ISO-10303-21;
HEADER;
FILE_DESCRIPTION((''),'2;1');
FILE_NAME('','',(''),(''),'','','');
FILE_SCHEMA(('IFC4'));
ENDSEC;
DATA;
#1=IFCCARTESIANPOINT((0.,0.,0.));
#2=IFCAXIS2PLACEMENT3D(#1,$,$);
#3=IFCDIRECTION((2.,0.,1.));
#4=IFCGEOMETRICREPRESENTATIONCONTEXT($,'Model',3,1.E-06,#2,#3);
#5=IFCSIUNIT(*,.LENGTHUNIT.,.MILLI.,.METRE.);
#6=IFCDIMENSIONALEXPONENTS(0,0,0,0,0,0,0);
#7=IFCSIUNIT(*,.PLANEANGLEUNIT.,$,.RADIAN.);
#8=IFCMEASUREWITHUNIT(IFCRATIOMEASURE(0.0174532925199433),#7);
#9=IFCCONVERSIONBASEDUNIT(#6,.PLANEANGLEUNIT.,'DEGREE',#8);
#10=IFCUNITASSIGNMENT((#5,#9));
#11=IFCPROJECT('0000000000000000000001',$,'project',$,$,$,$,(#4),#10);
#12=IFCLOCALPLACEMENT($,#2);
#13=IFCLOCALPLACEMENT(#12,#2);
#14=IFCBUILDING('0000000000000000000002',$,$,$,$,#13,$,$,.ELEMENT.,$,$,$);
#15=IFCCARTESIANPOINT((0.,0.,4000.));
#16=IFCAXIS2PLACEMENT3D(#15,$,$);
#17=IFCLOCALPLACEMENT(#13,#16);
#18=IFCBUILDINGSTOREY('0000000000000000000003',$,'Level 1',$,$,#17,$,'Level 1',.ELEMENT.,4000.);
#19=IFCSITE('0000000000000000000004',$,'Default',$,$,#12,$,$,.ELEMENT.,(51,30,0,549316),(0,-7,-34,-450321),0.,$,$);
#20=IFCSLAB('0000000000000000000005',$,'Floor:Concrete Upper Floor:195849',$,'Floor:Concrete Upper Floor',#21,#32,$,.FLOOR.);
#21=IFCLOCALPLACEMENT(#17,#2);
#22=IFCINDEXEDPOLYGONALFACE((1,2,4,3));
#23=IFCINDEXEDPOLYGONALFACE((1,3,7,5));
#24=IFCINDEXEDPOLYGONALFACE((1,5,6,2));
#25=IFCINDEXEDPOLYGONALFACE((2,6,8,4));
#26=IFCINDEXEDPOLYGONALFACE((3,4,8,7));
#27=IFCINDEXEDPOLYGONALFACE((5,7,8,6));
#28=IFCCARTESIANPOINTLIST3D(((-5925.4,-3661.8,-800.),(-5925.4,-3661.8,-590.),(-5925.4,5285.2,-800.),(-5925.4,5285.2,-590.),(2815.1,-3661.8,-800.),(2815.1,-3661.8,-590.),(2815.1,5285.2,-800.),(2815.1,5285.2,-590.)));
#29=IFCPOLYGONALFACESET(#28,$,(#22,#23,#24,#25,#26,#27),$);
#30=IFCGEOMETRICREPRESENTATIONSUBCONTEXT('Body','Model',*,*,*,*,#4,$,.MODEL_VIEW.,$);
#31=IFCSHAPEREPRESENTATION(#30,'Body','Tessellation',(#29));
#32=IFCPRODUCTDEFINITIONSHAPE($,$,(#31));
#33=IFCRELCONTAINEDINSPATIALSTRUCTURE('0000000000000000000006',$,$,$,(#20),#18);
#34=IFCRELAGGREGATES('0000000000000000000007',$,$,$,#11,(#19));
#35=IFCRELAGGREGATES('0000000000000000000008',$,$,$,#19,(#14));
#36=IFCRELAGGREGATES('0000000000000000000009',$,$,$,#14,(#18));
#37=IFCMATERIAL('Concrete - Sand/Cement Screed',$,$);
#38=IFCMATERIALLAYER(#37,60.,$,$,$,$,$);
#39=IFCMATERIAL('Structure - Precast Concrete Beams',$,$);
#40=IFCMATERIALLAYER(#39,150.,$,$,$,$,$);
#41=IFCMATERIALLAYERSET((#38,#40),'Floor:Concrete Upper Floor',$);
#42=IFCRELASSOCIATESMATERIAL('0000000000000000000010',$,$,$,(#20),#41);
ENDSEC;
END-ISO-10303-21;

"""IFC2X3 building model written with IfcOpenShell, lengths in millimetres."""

from ifc_helpers import new_model, entity, si_unit, converted_unit, direction, frame, frame_2d, origin, place, context, subcontext, project, spatial, rectangle, extrude, material, layer, layer_set, layer_usage, element, save


model = new_model("IFC2X3")

# Units and contexts
model_context = context("Model", 3, precision=1e-06, world=origin(), true_north=direction((2.0, 0.0, 1.0)))
body_context = subcontext(model_context, "Body", "Model", "MODEL_VIEW")
ifc_project = project(units=[si_unit("LENGTHUNIT", "METRE", prefix="MILLI"), converted_unit("PLANEANGLEUNIT", "DEGREE", entity("IfcRatioMeasure", 0.0174532925199433), si_unit("PLANEANGLEUNIT", "RADIAN"), dimensions=[0, 0, 0, 0, 0, 0, 0])], contexts=[model_context])

# Site, building, storey
site_placement = place(None, origin())
site = spatial("IfcSite", under=ifc_project, at=site_placement, Name="Default", CompositionType="ELEMENT", RefLatitude=(51, 30, 0, 549316), RefLongitude=(0, -7, -34, -450321), RefElevation=0.0)
building_placement = place(site_placement, origin())
building = spatial("IfcBuilding", under=site, at=building_placement, CompositionType="ELEMENT")
storey_placement = place(building_placement, frame((0.0, 0.0, 4000.0)))
storey = spatial("IfcBuildingStorey", under=building, at=storey_placement, Name="Level 1", LongName="Level 1", CompositionType="ELEMENT", Elevation=4000.0)

# Slab
ifc_material_1 = material(Name="Concrete - Sand/Cement Screed")
ifc_layer_1 = layer(ifc_material_1, 60.0)
ifc_material_2 = material(Name="Structure - Precast Concrete Beams")
ifc_layer_2 = layer(ifc_material_2, 150.0)
ifc_layer_set = layer_set([ifc_layer_1, ifc_layer_2], Name="Floor:Concrete Upper Floor")
ifc_layer_usage = layer_usage(ifc_layer_set, "AXIS3", "POSITIVE", 0.0)
slab_placement = place(storey_placement, origin())
element("IfcSlab", 1, at=slab_placement, inside=storey, material=ifc_layer_usage, Name="Floor:Concrete Upper Floor:195849", ObjectType="Floor:Concrete Upper Floor", PredefinedType="FLOOR", context=body_context, shape_type="SweptSolid", body=[
    extrude(rectangle(XDim=8947.0, YDim=8740.5, at=frame_2d((0.0, 0.0), x_axis=(1.0, 0.0))), frame((-1555.1, 811.7, -590.0), z_axis=(0.0, 0.0, -1.0), x_axis=(0.0, 1.0, 0.0)), (0.0, 0.0, 1.0), 210.0),
])

save(model, "model.ifc")
